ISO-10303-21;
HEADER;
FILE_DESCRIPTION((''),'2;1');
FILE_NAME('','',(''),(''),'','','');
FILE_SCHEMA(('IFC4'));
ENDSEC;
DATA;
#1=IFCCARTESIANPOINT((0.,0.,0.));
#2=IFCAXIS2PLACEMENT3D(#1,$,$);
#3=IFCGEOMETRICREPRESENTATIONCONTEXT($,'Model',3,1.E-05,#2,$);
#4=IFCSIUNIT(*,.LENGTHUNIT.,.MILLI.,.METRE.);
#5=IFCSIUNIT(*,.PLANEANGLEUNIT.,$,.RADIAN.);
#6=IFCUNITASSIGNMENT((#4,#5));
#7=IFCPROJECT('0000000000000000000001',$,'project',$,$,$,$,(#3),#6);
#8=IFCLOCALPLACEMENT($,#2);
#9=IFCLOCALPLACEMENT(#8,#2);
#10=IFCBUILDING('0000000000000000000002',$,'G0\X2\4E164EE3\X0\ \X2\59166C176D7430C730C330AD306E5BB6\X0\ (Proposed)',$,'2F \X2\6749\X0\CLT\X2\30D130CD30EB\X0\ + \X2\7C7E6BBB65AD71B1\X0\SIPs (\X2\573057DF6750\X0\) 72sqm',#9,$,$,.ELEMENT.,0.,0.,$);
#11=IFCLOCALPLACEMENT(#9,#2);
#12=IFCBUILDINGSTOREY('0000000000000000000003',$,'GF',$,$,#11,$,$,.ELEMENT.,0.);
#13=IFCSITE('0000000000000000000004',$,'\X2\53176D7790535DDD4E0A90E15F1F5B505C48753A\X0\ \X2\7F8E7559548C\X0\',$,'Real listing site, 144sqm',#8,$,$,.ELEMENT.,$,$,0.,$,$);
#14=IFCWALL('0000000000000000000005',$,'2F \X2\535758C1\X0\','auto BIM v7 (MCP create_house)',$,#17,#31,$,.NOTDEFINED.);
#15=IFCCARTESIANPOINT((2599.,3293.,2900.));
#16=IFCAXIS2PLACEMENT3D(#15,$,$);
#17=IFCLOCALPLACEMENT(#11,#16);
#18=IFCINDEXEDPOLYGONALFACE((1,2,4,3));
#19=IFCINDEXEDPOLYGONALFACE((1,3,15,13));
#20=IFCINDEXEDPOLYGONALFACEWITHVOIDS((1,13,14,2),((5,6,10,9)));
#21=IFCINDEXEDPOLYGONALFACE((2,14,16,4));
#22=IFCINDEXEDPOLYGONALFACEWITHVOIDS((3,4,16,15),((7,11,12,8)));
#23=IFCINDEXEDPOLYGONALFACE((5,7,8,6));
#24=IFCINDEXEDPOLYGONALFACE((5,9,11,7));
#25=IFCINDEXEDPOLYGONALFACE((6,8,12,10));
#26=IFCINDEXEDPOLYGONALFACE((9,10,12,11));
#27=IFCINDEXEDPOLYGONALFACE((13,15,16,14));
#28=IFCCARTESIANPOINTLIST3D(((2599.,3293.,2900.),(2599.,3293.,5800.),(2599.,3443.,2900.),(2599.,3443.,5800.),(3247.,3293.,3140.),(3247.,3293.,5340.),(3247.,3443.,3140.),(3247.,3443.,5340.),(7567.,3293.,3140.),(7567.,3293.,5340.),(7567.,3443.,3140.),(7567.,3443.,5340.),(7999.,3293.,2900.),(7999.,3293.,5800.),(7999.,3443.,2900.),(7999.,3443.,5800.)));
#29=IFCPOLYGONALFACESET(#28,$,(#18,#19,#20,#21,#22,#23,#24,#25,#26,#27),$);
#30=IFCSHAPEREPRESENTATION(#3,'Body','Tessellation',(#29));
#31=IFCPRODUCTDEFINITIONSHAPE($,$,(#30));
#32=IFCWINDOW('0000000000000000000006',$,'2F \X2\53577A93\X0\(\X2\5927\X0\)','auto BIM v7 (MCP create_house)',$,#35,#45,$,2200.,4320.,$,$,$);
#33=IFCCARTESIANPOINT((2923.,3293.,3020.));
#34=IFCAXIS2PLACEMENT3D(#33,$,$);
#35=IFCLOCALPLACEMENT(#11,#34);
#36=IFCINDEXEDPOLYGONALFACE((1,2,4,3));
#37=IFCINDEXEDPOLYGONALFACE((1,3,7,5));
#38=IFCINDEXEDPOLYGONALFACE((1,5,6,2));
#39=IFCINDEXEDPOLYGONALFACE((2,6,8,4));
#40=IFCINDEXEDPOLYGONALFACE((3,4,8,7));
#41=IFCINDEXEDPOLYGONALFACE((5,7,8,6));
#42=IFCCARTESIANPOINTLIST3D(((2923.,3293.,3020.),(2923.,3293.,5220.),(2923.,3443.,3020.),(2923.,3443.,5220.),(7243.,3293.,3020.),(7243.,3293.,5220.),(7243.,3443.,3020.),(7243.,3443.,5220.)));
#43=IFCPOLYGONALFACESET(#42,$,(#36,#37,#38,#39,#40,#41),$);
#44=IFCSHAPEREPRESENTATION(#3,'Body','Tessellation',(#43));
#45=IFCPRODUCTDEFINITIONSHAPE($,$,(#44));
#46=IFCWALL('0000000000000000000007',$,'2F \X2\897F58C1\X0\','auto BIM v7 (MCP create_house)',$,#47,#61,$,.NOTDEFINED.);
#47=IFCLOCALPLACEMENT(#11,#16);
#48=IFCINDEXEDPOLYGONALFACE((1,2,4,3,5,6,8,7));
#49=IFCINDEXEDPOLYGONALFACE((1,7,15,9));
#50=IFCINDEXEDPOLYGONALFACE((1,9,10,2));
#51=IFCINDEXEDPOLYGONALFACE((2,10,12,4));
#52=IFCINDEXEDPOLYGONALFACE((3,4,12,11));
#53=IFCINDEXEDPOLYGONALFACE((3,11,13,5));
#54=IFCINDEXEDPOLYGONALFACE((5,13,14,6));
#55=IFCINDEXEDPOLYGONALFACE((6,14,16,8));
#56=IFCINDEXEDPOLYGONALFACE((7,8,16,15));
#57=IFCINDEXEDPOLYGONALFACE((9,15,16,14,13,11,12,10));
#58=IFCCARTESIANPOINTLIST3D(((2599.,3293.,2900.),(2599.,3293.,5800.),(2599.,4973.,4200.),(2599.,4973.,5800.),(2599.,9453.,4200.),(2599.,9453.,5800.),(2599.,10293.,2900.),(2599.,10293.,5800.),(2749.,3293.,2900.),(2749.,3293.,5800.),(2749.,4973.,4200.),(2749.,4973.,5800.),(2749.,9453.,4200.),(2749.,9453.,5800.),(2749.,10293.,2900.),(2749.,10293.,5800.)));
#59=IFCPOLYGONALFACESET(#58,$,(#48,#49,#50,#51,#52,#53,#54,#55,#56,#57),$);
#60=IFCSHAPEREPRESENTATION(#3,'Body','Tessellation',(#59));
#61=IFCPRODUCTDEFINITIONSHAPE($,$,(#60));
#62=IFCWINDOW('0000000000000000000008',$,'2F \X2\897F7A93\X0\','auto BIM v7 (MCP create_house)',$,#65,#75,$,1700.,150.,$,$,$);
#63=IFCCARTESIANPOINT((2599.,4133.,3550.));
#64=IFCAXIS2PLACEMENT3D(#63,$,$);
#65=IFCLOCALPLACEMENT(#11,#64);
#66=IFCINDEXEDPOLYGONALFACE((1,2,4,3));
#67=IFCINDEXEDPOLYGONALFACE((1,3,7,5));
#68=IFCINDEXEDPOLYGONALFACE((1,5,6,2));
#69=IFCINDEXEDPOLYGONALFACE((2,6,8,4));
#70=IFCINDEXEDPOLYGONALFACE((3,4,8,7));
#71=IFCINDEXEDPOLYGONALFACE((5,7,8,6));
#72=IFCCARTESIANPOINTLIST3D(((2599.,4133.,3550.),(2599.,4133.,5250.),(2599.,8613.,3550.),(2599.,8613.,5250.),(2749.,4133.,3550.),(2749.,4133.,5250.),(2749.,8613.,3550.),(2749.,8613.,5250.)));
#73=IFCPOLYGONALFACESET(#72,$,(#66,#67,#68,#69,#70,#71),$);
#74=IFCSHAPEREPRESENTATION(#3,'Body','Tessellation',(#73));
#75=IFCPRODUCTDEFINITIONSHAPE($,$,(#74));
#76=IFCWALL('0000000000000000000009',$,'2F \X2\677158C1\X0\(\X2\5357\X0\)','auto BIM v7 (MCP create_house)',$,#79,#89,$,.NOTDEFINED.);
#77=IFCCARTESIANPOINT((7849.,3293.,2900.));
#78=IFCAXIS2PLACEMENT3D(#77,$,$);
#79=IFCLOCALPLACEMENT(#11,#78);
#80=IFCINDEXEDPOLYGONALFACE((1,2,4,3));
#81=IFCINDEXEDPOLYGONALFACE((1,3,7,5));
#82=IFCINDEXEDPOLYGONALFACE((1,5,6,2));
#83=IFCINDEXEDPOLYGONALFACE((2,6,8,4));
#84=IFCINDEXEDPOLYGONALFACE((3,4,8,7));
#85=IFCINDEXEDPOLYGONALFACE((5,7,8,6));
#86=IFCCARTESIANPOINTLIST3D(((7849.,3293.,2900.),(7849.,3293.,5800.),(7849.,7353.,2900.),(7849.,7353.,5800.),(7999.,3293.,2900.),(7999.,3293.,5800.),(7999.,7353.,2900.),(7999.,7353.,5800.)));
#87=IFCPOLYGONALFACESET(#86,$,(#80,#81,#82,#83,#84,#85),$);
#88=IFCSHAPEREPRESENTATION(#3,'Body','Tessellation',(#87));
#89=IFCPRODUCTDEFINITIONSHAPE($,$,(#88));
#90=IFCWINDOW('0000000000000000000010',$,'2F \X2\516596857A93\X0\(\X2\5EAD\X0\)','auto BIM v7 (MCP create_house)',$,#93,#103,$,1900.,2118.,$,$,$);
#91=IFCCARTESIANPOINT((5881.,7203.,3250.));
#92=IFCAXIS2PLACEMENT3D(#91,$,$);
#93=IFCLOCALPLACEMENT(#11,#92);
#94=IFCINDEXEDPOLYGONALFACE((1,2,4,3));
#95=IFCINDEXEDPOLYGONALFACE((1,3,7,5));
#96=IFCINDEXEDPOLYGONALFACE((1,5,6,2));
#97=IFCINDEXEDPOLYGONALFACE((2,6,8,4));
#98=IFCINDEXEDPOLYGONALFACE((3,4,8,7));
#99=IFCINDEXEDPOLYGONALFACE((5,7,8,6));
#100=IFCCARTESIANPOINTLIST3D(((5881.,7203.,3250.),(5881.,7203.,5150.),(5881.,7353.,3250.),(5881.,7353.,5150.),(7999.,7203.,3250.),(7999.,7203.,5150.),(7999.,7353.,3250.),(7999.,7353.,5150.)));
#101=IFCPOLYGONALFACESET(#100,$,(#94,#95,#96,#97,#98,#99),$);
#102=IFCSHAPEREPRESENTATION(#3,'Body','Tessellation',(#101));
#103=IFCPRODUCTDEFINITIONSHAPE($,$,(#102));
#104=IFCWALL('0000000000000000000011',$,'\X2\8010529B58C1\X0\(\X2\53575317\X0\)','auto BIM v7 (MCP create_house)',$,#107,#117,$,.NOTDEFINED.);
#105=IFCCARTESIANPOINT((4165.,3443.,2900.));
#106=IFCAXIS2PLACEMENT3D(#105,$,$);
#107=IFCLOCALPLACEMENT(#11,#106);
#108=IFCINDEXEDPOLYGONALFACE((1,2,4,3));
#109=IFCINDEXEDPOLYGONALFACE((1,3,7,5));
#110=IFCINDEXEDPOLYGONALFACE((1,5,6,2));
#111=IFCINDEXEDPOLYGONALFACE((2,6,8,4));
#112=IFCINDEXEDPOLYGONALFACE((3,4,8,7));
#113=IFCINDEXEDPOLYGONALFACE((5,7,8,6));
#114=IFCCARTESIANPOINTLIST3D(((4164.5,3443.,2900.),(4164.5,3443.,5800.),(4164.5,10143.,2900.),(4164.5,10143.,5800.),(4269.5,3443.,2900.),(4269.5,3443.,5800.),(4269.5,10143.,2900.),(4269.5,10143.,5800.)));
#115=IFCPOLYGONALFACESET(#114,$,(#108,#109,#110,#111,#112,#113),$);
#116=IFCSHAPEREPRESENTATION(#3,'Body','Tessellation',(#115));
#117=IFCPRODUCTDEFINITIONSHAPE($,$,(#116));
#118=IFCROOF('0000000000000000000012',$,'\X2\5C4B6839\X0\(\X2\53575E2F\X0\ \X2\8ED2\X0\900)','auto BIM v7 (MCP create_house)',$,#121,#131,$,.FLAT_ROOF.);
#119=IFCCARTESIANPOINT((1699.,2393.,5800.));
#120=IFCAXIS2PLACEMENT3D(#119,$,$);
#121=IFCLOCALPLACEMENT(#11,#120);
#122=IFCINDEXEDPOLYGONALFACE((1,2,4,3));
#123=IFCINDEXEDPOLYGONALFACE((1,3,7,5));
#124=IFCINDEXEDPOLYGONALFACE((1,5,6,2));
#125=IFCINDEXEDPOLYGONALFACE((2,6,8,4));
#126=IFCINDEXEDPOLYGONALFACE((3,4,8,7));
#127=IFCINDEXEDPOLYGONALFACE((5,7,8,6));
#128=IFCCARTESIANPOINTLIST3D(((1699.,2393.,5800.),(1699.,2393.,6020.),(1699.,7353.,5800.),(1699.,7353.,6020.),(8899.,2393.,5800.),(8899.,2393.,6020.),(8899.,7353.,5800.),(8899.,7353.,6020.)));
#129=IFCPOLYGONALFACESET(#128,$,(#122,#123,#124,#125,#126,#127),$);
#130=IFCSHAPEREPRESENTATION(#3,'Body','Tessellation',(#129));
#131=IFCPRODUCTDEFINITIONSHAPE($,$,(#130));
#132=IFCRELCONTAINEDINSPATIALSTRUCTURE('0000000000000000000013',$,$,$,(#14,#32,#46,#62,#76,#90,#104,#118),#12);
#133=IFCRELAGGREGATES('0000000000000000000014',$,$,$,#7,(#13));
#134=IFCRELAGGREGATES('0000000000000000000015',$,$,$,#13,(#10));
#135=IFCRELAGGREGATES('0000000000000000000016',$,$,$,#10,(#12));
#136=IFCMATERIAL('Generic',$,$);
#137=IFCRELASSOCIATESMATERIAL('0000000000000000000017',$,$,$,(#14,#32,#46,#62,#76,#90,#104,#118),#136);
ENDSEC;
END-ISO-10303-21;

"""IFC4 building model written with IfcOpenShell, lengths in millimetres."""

from ifc_helpers import new_model, si_unit, frame, frame_2d, origin, place, context, project, spatial, rectangle, extrude, material, element, fill, save


model = new_model("IFC4")

# Units and contexts
model_context = context("Model", 3, precision=1e-05, world=origin())
ifc_project = project(units=[si_unit("LENGTHUNIT", "METRE", prefix="MILLI"), si_unit("PLANEANGLEUNIT", "RADIAN")], contexts=[model_context])

# Site, building, storey
site_placement = place(None, origin())
site = spatial("IfcSite", under=ifc_project, at=site_placement, Name="北海道川上郡弟子屈町 美留和", ObjectType="Real listing site, 144sqm", CompositionType="ELEMENT", RefElevation=0.0)
building_placement = place(site_placement, origin())
building = spatial("IfcBuilding", under=site, at=building_placement, Name="G0世代 外気浴デッキの家 (Proposed)", ObjectType="2F 杉CLTパネル + 籾殻断熱SIPs (地域材) 72sqm", CompositionType="ELEMENT", ElevationOfRefHeight=0.0, ElevationOfTerrain=0.0)
storey_placement = place(building_placement, origin())
storey = spatial("IfcBuildingStorey", under=building, at=storey_placement, Name="GF", CompositionType="ELEMENT", Elevation=0.0)

# Shared definitions
ifc_material = material(Name="Generic")

# Walls, openings, windows
wall_1_placement = place(storey_placement, frame((2599.0, 3293.0, 2900.0)))
wall_1 = element("IfcWall", 1, at=wall_1_placement, inside=storey, material=ifc_material, Name="2F 南壁", Description="auto BIM v7 (MCP create_house)", PredefinedType="NOTDEFINED", context=model_context, shape_type="SweptSolid", body=[
    extrude(rectangle(XDim=5400.0, YDim=150.0, at=frame_2d((2700.0, 75.0))), frame((2599.0, 3293.0, 2900.0)), (0.0, 0.0, 1.0), 2900.0),
])
opening_1_placement = place(storey_placement, frame((2923.0, 3293.0, 3020.0)))
opening_1 = element("IfcOpeningElement", 2, at=opening_1_placement, cuts=wall_1, PredefinedType="NOTDEFINED", context=model_context, shape_type="SweptSolid", body=[
    extrude(rectangle(XDim=4320.0, YDim=150.0, at=frame_2d((2160.0, 75.0))), frame((2923.0, 3293.0, 3020.0)), (0.0, 0.0, 1.0), 2200.0),
])
window_1_placement = place(storey_placement, frame((2923.0, 3293.0, 3020.0)))
window_1 = element("IfcWindow", 3, at=window_1_placement, inside=storey, material=ifc_material, Name="2F 南窓(大)", Description="auto BIM v7 (MCP create_house)", OverallHeight=2200.0, OverallWidth=4320.0, context=model_context, shape_type="SweptSolid", body=[
    extrude(rectangle(XDim=4320.0, YDim=150.0, at=frame_2d((2160.0, 75.0))), frame((2923.0, 3293.0, 3020.0)), (0.0, 0.0, 1.0), 2200.0),
])
fill(opening_1, window_1)
wall_2_placement = place(storey_placement, frame((2599.0, 3293.0, 2900.0)))
wall_2 = element("IfcWall", 4, at=wall_2_placement, inside=storey, material=ifc_material, Name="2F 西壁", Description="auto BIM v7 (MCP create_house)", PredefinedType="NOTDEFINED", context=model_context, shape_type="SweptSolid", body=[
    extrude(rectangle(XDim=150.0, YDim=7000.0, at=frame_2d((75.0, 3500.0))), frame((2599.0, 3293.0, 2900.0)), (0.0, 0.0, 1.0), 2900.0),
])
opening_2_placement = place(storey_placement, frame((2599.0, 4133.0, 3550.0)))
opening_2 = element("IfcOpeningElement", 5, at=opening_2_placement, cuts=wall_2, PredefinedType="NOTDEFINED", context=model_context, shape_type="SweptSolid", body=[
    extrude(rectangle(XDim=150.0, YDim=4480.0, at=frame_2d((75.0, 2240.0))), frame((2599.0, 4133.0, 3550.0)), (0.0, 0.0, 1.0), 1700.0),
])
window_2_placement = place(storey_placement, frame((2599.0, 4133.0, 3550.0)))
window_2 = element("IfcWindow", 6, at=window_2_placement, inside=storey, material=ifc_material, Name="2F 西窓", Description="auto BIM v7 (MCP create_house)", OverallHeight=1700.0, OverallWidth=150.0, context=model_context, shape_type="SweptSolid", body=[
    extrude(rectangle(XDim=150.0, YDim=4480.0, at=frame_2d((75.0, 2240.0))), frame((2599.0, 4133.0, 3550.0)), (0.0, 0.0, 1.0), 1700.0),
])
fill(opening_2, window_2)
wall_3_placement = place(storey_placement, frame((7849.0, 3293.0, 2900.0)))
wall_3 = element("IfcWall", 7, at=wall_3_placement, inside=storey, material=ifc_material, Name="2F 東壁(南)", Description="auto BIM v7 (MCP create_house)", PredefinedType="NOTDEFINED", context=model_context, shape_type="SweptSolid", body=[
    extrude(rectangle(XDim=150.0, YDim=4060.0, at=frame_2d((75.0, 2030.0))), frame((7849.0, 3293.0, 2900.0)), (0.0, 0.0, 1.0), 2900.0),
])
opening_3_placement = place(storey_placement, frame((5881.0, 7203.0, 3250.0)))
opening_3 = element("IfcOpeningElement", 8, at=opening_3_placement, cuts=wall_3, PredefinedType="NOTDEFINED", context=model_context, shape_type="SweptSolid", body=[
    extrude(rectangle(XDim=2118.0, YDim=150.0, at=frame_2d((1059.0, 75.0))), frame((5881.0, 7203.0, 3250.0)), (0.0, 0.0, 1.0), 1900.0),
])
window_3_placement = place(storey_placement, frame((5881.0, 7203.0, 3250.0)))
window_3 = element("IfcWindow", 9, at=window_3_placement, inside=storey, material=ifc_material, Name="2F 入隅窓(庭)", Description="auto BIM v7 (MCP create_house)", OverallHeight=1900.0, OverallWidth=2118.0, context=model_context, shape_type="SweptSolid", body=[
    extrude(rectangle(XDim=2118.0, YDim=150.0, at=frame_2d((1059.0, 75.0))), frame((5881.0, 7203.0, 3250.0)), (0.0, 0.0, 1.0), 1900.0),
])
fill(opening_3, window_3)

# Wall
wall_4_placement = place(storey_placement, frame((4165.0, 3443.0, 2900.0)))
element("IfcWall", 10, at=wall_4_placement, inside=storey, material=ifc_material, Name="耐力壁(南北)", Description="auto BIM v7 (MCP create_house)", PredefinedType="NOTDEFINED", context=model_context, shape_type="SweptSolid", body=[
    extrude(rectangle(XDim=105.0, YDim=6700.0, at=frame_2d((52.0, 3350.0))), frame((4165.0, 3443.0, 2900.0)), (0.0, 0.0, 1.0), 2900.0),
])

# Roof
for number, where, name in (
    (11, (1699.0, 2393.0, 5800.0), "屋根(南帯 軒900)"),
):
    element("IfcRoof", number, at=place(storey_placement, frame(where)), inside=storey, material=ifc_material, Name=name, Description="auto BIM v7 (MCP create_house)", PredefinedType="FLAT_ROOF", context=model_context, shape_type="SweptSolid", body=[
        extrude(rectangle(XDim=7200.0, YDim=4960.0, at=frame_2d((3600.0, 2480.0))), frame((1699.0, 2393.0, 5800.0)), (0.0, 0.0, 1.0), 220.0),
    ])

save(model, "model.ifc")
